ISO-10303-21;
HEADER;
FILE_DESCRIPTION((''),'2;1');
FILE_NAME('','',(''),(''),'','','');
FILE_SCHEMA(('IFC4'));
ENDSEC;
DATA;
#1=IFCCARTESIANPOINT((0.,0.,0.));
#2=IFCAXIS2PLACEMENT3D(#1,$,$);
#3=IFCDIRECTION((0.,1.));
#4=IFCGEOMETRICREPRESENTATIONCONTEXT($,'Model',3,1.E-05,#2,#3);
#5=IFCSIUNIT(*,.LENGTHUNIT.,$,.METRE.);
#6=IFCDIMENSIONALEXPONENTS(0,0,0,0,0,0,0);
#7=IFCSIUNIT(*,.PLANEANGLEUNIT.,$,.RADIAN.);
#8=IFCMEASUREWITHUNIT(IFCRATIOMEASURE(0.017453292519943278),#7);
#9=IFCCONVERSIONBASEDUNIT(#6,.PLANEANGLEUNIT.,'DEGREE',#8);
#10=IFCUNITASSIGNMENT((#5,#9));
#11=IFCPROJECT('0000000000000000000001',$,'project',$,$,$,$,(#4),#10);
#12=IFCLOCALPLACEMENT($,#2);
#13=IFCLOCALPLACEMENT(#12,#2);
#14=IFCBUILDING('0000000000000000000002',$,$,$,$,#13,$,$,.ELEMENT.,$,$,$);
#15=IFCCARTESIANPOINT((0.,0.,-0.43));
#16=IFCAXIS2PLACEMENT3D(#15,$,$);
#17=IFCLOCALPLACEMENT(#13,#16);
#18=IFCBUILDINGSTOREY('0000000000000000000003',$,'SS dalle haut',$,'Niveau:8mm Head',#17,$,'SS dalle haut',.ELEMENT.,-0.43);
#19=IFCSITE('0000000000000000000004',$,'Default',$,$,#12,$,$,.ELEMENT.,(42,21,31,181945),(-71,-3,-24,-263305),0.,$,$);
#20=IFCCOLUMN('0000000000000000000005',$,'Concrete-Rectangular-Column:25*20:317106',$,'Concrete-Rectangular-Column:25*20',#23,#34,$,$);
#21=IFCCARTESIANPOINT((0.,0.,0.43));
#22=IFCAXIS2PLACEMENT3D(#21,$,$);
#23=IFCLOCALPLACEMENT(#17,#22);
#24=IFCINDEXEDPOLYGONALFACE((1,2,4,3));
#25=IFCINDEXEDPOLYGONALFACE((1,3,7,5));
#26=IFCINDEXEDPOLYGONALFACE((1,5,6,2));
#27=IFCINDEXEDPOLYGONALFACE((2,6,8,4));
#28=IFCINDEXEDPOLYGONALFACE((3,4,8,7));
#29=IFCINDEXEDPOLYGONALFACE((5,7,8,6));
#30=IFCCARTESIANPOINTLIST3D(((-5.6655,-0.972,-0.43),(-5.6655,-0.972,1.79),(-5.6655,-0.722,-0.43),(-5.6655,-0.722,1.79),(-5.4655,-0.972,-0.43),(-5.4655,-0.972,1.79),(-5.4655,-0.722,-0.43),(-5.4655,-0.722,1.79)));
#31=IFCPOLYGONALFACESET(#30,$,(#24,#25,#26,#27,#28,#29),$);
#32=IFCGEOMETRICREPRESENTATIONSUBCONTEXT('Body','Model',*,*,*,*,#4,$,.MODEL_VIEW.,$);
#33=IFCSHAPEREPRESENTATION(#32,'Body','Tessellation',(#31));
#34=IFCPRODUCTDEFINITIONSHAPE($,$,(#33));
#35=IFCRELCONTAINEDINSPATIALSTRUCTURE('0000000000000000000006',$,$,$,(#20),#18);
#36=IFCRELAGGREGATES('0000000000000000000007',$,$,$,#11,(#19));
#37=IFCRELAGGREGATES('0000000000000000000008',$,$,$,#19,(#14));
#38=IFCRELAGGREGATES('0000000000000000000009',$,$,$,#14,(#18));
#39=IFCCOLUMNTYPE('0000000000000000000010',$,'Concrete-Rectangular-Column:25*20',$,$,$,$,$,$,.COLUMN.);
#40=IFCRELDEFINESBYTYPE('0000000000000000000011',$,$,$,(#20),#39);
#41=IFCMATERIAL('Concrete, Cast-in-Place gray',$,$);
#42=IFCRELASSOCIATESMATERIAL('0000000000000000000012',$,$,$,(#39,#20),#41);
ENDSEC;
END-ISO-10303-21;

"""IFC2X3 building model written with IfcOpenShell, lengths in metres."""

from ifc_helpers import new_model, entity, si_unit, converted_unit, direction, frame, frame_2d, origin, place, context, subcontext, project, spatial, rectangle, extrude, source, transform, mapped, material, type_object, type_shapes, element, save


model = new_model("IFC2X3")

# Units and contexts
model_context = context("Model", 3, precision=1e-05, world=origin(), true_north=direction((0.0, 1.0)))
body_context = subcontext(model_context, "Body", "Model", "MODEL_VIEW")
ifc_project = project(units=[si_unit("LENGTHUNIT", "METRE"), converted_unit("PLANEANGLEUNIT", "DEGREE", entity("IfcRatioMeasure", 0.017453292519943278), si_unit("PLANEANGLEUNIT", "RADIAN"), dimensions=[0, 0, 0, 0, 0, 0, 0])], contexts=[model_context])

# Site, building, storey
site_placement = place(None, origin())
site = spatial("IfcSite", under=ifc_project, at=site_placement, Name="Default", CompositionType="ELEMENT", RefLatitude=(42, 21, 31, 181945), RefLongitude=(-71, -3, -24, -263305), RefElevation=0.0)
building_placement = place(site_placement, origin())
building = spatial("IfcBuilding", under=site, at=building_placement, CompositionType="ELEMENT")
storey_placement = place(building_placement, frame((0.0, 0.0, -0.43)))
storey = spatial("IfcBuildingStorey", under=building, at=storey_placement, Name="SS dalle haut", ObjectType="Niveau:8mm Head", LongName="SS dalle haut", CompositionType="ELEMENT", Elevation=-0.43)

# Column
ifc_material_1 = material(Name="Concrete, Cast-in-Place gray")
column_type = type_object("IfcColumnType", Name="Concrete-Rectangular-Column:25*20", PredefinedType="COLUMN", material=ifc_material_1)
shared_shape = source(origin(), body_context, "Body", "SweptSolid", [
    extrude(rectangle(XDim=0.25, YDim=0.2, at=frame_2d((0.0, 0.0), x_axis=(1.0, 0.0))), frame((-5.5655, -0.847, -0.43), z_axis=(0.0, 0.0, 1.0), x_axis=(0.0, -1.0, 0.0)), (0.0, 0.0, 1.0), 2.22),
])
type_shapes(column_type, [shared_shape])
column_placement = place(storey_placement, frame((0.0, 0.0, 0.43)))
element("IfcColumn", 1, at=column_placement, inside=storey, type_object=column_type, material=ifc_material_1, Name="Concrete-Rectangular-Column:25*20:317106", ObjectType="Concrete-Rectangular-Column:25*20", context=body_context, shape_type="MappedRepresentation", body=[
    mapped(shared_shape, transform((0.0, 0.0, 0.0), scale=1.0)),
])

save(model, "model.ifc")
